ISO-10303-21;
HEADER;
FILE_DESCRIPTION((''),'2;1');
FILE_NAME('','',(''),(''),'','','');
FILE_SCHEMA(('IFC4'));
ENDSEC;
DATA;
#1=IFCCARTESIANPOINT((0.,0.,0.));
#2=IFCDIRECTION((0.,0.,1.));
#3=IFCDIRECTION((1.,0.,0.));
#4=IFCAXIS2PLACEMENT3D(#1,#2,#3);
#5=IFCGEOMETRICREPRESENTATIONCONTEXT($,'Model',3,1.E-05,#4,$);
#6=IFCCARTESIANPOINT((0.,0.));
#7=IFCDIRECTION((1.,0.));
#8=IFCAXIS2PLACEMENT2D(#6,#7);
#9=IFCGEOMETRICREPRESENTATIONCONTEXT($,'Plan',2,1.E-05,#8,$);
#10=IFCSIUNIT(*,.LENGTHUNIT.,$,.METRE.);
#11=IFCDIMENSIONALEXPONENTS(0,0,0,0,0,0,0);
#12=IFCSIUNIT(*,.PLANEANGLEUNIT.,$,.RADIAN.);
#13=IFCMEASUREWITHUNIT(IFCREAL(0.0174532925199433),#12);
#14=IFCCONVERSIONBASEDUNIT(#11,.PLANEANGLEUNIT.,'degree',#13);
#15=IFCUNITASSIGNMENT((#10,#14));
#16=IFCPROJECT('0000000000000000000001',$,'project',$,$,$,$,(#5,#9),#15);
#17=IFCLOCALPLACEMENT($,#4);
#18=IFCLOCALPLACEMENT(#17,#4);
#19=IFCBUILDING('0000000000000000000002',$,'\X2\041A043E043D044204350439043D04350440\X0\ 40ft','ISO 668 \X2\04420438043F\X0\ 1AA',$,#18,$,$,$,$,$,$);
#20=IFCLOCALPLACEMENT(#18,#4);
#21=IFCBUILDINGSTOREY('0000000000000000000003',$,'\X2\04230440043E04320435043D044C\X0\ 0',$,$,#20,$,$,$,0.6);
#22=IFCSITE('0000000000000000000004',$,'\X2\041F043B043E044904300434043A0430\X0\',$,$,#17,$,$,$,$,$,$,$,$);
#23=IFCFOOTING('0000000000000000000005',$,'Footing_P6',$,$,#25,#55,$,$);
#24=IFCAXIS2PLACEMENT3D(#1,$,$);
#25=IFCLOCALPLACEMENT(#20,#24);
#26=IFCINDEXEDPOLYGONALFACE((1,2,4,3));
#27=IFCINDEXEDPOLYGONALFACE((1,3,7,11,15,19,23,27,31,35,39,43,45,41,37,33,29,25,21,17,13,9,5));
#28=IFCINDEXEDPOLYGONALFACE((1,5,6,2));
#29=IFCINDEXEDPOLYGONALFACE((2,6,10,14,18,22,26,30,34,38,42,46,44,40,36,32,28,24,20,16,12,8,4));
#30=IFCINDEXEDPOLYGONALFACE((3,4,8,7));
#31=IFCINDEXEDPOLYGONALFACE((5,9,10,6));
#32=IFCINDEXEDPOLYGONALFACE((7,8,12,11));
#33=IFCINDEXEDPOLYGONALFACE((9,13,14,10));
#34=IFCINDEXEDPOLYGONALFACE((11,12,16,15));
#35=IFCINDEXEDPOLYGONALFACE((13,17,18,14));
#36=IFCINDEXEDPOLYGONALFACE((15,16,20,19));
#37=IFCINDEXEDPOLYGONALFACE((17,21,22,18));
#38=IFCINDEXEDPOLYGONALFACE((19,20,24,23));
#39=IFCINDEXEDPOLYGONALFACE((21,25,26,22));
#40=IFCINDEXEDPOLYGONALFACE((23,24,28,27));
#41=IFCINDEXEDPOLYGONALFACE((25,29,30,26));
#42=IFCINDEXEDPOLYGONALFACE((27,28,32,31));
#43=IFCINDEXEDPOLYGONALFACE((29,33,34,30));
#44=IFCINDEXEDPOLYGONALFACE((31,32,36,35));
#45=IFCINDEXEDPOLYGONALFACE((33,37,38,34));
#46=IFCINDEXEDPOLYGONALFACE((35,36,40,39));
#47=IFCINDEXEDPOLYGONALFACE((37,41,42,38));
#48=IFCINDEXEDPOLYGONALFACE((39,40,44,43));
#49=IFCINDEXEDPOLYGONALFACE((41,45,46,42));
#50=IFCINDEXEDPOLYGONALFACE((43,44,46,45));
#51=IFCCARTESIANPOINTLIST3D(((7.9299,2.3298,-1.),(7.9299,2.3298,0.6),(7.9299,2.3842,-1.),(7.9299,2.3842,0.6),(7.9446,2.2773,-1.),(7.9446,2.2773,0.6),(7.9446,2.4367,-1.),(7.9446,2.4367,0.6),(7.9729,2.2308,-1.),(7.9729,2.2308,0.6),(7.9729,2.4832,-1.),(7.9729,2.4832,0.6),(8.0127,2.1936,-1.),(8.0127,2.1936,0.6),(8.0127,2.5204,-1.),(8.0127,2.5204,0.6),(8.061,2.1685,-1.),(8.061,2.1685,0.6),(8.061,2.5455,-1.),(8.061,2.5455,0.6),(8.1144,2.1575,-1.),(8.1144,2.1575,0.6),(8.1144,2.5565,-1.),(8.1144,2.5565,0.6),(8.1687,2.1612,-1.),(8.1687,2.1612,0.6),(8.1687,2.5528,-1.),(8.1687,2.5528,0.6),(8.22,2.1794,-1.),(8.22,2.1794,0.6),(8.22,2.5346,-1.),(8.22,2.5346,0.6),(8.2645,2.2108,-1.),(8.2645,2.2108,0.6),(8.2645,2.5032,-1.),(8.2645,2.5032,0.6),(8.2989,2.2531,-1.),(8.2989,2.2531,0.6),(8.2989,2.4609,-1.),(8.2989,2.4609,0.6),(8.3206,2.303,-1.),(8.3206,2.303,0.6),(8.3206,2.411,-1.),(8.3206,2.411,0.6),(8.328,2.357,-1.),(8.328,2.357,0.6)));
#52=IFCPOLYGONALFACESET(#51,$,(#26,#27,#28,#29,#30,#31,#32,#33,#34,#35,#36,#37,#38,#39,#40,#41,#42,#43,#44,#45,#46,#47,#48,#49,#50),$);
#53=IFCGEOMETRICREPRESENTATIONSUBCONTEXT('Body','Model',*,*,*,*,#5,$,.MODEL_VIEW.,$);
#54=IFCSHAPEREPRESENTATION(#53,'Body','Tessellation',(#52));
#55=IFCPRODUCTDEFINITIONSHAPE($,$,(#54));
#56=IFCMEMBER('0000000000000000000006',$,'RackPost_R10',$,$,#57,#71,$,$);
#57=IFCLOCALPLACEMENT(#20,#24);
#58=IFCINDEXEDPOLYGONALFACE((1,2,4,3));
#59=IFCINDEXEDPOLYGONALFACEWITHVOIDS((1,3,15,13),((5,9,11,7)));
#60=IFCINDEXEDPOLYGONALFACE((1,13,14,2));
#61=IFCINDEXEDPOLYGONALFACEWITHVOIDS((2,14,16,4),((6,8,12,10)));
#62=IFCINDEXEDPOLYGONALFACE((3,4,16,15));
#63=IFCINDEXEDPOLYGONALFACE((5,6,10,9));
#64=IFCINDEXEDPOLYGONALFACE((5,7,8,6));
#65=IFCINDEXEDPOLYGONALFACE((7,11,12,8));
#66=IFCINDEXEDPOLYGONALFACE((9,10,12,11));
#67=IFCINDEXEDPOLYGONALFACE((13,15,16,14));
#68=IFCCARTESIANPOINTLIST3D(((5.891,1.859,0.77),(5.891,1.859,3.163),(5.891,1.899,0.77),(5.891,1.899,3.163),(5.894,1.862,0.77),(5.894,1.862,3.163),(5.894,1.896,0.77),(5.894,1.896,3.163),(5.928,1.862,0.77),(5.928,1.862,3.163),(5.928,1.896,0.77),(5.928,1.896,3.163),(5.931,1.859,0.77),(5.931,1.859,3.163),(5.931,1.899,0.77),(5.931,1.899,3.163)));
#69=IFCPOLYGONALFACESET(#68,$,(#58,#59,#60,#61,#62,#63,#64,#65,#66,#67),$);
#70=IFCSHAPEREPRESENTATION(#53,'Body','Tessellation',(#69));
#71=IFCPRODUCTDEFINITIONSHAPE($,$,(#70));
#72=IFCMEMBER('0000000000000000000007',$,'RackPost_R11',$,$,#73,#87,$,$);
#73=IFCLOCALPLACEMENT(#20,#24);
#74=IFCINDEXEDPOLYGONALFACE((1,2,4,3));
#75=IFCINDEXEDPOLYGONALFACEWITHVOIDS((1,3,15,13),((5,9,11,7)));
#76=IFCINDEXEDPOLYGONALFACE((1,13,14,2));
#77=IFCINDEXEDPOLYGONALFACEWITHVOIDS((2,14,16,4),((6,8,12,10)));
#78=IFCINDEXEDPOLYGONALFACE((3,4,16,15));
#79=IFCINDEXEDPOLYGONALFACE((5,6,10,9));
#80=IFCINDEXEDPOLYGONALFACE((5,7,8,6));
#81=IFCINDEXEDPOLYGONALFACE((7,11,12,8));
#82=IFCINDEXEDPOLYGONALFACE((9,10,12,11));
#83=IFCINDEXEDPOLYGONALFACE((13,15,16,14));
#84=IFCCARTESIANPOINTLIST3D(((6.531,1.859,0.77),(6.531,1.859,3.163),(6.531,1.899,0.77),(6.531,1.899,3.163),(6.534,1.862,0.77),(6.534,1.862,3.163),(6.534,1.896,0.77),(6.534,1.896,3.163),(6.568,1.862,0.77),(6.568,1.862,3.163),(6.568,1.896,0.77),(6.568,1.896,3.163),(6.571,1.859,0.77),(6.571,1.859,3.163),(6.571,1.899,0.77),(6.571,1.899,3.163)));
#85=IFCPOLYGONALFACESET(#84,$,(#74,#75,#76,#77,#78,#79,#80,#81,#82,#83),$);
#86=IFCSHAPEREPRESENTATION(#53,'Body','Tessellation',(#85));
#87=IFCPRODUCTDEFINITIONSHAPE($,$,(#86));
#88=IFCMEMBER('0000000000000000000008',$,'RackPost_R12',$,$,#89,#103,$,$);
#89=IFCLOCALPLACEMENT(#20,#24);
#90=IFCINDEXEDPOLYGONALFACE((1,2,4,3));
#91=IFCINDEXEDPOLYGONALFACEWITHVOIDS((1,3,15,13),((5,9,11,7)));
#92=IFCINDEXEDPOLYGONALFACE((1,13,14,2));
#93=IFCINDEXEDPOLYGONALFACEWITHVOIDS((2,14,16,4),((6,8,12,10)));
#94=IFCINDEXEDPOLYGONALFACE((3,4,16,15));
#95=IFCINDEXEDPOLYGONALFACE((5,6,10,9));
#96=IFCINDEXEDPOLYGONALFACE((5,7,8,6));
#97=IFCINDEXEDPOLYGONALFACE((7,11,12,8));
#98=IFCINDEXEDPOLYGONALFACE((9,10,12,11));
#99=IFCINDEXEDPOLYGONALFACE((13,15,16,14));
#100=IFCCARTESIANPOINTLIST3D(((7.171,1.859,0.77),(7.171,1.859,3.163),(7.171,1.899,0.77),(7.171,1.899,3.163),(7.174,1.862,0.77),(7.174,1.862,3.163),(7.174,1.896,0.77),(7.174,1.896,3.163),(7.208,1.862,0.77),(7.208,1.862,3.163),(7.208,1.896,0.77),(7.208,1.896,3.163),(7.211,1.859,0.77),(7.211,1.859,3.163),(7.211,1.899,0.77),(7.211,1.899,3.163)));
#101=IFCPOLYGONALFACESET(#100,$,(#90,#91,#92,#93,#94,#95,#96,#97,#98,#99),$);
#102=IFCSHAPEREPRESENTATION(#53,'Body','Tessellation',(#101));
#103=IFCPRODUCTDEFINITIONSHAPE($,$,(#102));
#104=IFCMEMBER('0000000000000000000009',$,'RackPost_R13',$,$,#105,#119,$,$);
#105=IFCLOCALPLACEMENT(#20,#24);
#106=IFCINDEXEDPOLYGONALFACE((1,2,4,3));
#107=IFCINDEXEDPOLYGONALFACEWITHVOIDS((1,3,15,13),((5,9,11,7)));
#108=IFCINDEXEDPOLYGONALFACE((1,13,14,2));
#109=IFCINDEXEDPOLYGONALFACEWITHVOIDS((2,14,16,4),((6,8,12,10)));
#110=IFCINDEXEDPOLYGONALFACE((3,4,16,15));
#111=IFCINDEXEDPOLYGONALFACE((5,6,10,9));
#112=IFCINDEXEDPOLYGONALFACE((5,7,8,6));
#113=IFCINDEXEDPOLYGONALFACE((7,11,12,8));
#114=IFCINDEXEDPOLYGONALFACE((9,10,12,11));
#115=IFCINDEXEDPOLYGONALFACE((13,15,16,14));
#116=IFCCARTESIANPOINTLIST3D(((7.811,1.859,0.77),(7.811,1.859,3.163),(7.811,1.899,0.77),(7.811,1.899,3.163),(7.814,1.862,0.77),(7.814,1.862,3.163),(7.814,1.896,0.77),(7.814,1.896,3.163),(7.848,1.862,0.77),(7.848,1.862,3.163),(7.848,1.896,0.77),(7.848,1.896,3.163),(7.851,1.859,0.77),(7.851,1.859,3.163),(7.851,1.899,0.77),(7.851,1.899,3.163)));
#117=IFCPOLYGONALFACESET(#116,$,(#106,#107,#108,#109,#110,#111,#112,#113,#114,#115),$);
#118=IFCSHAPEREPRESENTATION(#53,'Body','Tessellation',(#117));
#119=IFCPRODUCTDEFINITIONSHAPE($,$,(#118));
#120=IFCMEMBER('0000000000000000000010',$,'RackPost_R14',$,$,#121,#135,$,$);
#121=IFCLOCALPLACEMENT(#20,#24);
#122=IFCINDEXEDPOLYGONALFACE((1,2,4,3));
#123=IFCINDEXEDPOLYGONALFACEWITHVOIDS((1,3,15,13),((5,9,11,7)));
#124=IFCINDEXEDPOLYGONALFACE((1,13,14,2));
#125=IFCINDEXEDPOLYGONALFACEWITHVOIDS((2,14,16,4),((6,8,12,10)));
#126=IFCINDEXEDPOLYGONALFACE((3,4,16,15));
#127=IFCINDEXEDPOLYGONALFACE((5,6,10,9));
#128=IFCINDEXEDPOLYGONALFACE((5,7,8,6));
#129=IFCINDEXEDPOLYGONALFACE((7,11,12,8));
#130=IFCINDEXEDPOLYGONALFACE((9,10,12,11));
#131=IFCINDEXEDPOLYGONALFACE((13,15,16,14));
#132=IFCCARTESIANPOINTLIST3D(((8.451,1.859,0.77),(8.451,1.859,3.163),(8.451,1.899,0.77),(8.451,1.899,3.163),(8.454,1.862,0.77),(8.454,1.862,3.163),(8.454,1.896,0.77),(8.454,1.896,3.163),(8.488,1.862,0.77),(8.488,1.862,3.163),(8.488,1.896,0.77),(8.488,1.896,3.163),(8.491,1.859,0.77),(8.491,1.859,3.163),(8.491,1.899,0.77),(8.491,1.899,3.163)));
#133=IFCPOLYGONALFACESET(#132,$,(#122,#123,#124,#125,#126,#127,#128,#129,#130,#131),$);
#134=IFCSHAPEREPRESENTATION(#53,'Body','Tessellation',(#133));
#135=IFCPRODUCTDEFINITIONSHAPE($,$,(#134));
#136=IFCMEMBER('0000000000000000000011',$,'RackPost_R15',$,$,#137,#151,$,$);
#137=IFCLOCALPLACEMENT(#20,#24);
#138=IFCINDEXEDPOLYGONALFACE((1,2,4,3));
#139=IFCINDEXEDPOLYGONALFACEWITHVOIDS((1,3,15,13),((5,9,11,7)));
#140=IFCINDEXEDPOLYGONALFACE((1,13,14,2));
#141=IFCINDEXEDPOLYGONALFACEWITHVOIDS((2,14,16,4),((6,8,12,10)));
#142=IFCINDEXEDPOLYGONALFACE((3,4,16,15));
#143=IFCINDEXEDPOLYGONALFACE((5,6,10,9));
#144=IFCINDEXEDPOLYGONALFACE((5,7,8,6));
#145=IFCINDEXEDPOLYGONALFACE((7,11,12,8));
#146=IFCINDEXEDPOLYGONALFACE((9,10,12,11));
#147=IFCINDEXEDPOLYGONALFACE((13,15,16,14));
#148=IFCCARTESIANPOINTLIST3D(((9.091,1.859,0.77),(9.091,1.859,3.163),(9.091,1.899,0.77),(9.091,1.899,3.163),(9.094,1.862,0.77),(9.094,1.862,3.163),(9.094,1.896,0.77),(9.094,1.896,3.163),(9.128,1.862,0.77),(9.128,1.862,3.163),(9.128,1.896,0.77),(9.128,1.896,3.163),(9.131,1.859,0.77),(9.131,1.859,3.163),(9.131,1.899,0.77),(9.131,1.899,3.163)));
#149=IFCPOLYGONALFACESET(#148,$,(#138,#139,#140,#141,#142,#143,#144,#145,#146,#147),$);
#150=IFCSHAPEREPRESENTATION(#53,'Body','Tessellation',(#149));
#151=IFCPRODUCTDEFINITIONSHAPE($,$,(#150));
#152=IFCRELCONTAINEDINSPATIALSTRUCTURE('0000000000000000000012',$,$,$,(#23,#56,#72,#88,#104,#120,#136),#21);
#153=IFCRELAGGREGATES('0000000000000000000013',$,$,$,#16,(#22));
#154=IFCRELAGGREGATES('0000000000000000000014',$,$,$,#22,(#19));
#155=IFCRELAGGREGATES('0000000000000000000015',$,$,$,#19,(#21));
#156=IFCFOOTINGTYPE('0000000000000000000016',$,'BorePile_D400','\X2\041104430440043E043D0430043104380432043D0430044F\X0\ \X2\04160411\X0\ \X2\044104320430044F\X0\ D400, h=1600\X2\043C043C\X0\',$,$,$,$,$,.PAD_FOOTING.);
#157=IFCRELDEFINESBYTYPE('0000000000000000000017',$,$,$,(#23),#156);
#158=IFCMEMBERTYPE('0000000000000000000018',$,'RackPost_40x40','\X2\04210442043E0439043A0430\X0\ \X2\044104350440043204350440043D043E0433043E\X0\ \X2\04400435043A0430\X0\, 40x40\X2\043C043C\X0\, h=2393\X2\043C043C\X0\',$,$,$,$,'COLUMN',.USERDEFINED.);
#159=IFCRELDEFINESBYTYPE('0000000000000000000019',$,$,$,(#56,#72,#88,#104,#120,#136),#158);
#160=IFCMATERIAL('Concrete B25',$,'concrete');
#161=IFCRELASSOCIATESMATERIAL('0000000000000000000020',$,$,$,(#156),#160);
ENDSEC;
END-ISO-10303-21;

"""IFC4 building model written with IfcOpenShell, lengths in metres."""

from ifc_helpers import new_model, entity, si_unit, converted_unit, frame, origin_with_axes, origin_2d_with_axis, place, context, subcontext, project, spatial, hollow_rectangle, circle, extrude, material, type_object, element, save


model = new_model("IFC4")

# Units and contexts
model_context = context("Model", 3, precision=1e-05, world=origin_with_axes())
plan_context = context("Plan", 2, precision=1e-05, world=origin_2d_with_axis())
body_context = subcontext(model_context, "Body", "Model", "MODEL_VIEW")
ifc_project = project(units=[si_unit("LENGTHUNIT", "METRE"), converted_unit("PLANEANGLEUNIT", "degree", entity("IfcReal", 0.0174532925199433), si_unit("PLANEANGLEUNIT", "RADIAN"), dimensions=[0, 0, 0, 0, 0, 0, 0])], contexts=[model_context, plan_context])

# Site, building, storey
site_placement = place(None, origin_with_axes())
site = spatial("IfcSite", under=ifc_project, at=site_placement, Name="Площадка")
building_placement = place(site_placement, origin_with_axes())
building = spatial("IfcBuilding", under=site, at=building_placement, Name="Контейнер 40ft", Description="ISO 668 тип 1AA")
storey_placement = place(building_placement, origin_with_axes())
storey = spatial("IfcBuildingStorey", under=building, at=storey_placement, Name="Уровень 0", Elevation=0.6)

# Footing
ifc_material = material(Name="Concrete B25", Category="concrete")
footing_type = type_object("IfcFootingType", Name="BorePile_D400", Description="Буронабивная ЖБ свая D400, h=1600мм", PredefinedType="PAD_FOOTING", material=ifc_material)
footing_placement = place(storey_placement, frame((8.128, 2.357, -1.0), z_axis=(0.0, 0.0, 1.0), x_axis=(1.0, 0.0, 0.0)))
element("IfcFooting", 1, at=footing_placement, inside=storey, type_object=footing_type, Name="Footing_P6", context=body_context, shape_type="SweptSolid", body=[
    extrude(circle(Radius=0.2), origin_with_axes(), (0.0, 0.0, 1.0), 1.6),
])

# Members
member_type = type_object("IfcMemberType", Name="RackPost_40x40", Description="Стойка серверного река, 40x40мм, h=2393мм", ElementType="COLUMN", PredefinedType="USERDEFINED")
for number, where, z_axis, x_axis, name in (
    (2, (5.911, 1.879, 0.77), (0.0, 0.0, 1.0), (1.0, 0.0, 0.0), "RackPost_R10"),
    (3, (6.551, 1.879, 0.77), (0.0, 0.0, 1.0), (1.0, 0.0, 0.0), "RackPost_R11"),
    (4, (7.191, 1.879, 0.77), (0.0, 0.0, 1.0), (1.0, 0.0, 0.0), "RackPost_R12"),
    (5, (7.831, 1.879, 0.77), (0.0, 0.0, 1.0), (1.0, 0.0, 0.0), "RackPost_R13"),
    (6, (8.471, 1.879, 0.77), (0.0, 0.0, 1.0), (1.0, 0.0, 0.0), "RackPost_R14"),
    (7, (9.111, 1.879, 0.77), (0.0, 0.0, 1.0), (1.0, 0.0, 0.0), "RackPost_R15"),
):
    element("IfcMember", number, at=place(storey_placement, frame(where, z_axis=z_axis, x_axis=x_axis)), inside=storey, type_object=member_type, Name=name, context=body_context, shape_type="SweptSolid", body=[
        extrude(hollow_rectangle(XDim=0.04, YDim=0.04, WallThickness=0.003), origin_with_axes(), (0.0, 0.0, 1.0), 2.393),
    ])

save(model, "model.ifc")
